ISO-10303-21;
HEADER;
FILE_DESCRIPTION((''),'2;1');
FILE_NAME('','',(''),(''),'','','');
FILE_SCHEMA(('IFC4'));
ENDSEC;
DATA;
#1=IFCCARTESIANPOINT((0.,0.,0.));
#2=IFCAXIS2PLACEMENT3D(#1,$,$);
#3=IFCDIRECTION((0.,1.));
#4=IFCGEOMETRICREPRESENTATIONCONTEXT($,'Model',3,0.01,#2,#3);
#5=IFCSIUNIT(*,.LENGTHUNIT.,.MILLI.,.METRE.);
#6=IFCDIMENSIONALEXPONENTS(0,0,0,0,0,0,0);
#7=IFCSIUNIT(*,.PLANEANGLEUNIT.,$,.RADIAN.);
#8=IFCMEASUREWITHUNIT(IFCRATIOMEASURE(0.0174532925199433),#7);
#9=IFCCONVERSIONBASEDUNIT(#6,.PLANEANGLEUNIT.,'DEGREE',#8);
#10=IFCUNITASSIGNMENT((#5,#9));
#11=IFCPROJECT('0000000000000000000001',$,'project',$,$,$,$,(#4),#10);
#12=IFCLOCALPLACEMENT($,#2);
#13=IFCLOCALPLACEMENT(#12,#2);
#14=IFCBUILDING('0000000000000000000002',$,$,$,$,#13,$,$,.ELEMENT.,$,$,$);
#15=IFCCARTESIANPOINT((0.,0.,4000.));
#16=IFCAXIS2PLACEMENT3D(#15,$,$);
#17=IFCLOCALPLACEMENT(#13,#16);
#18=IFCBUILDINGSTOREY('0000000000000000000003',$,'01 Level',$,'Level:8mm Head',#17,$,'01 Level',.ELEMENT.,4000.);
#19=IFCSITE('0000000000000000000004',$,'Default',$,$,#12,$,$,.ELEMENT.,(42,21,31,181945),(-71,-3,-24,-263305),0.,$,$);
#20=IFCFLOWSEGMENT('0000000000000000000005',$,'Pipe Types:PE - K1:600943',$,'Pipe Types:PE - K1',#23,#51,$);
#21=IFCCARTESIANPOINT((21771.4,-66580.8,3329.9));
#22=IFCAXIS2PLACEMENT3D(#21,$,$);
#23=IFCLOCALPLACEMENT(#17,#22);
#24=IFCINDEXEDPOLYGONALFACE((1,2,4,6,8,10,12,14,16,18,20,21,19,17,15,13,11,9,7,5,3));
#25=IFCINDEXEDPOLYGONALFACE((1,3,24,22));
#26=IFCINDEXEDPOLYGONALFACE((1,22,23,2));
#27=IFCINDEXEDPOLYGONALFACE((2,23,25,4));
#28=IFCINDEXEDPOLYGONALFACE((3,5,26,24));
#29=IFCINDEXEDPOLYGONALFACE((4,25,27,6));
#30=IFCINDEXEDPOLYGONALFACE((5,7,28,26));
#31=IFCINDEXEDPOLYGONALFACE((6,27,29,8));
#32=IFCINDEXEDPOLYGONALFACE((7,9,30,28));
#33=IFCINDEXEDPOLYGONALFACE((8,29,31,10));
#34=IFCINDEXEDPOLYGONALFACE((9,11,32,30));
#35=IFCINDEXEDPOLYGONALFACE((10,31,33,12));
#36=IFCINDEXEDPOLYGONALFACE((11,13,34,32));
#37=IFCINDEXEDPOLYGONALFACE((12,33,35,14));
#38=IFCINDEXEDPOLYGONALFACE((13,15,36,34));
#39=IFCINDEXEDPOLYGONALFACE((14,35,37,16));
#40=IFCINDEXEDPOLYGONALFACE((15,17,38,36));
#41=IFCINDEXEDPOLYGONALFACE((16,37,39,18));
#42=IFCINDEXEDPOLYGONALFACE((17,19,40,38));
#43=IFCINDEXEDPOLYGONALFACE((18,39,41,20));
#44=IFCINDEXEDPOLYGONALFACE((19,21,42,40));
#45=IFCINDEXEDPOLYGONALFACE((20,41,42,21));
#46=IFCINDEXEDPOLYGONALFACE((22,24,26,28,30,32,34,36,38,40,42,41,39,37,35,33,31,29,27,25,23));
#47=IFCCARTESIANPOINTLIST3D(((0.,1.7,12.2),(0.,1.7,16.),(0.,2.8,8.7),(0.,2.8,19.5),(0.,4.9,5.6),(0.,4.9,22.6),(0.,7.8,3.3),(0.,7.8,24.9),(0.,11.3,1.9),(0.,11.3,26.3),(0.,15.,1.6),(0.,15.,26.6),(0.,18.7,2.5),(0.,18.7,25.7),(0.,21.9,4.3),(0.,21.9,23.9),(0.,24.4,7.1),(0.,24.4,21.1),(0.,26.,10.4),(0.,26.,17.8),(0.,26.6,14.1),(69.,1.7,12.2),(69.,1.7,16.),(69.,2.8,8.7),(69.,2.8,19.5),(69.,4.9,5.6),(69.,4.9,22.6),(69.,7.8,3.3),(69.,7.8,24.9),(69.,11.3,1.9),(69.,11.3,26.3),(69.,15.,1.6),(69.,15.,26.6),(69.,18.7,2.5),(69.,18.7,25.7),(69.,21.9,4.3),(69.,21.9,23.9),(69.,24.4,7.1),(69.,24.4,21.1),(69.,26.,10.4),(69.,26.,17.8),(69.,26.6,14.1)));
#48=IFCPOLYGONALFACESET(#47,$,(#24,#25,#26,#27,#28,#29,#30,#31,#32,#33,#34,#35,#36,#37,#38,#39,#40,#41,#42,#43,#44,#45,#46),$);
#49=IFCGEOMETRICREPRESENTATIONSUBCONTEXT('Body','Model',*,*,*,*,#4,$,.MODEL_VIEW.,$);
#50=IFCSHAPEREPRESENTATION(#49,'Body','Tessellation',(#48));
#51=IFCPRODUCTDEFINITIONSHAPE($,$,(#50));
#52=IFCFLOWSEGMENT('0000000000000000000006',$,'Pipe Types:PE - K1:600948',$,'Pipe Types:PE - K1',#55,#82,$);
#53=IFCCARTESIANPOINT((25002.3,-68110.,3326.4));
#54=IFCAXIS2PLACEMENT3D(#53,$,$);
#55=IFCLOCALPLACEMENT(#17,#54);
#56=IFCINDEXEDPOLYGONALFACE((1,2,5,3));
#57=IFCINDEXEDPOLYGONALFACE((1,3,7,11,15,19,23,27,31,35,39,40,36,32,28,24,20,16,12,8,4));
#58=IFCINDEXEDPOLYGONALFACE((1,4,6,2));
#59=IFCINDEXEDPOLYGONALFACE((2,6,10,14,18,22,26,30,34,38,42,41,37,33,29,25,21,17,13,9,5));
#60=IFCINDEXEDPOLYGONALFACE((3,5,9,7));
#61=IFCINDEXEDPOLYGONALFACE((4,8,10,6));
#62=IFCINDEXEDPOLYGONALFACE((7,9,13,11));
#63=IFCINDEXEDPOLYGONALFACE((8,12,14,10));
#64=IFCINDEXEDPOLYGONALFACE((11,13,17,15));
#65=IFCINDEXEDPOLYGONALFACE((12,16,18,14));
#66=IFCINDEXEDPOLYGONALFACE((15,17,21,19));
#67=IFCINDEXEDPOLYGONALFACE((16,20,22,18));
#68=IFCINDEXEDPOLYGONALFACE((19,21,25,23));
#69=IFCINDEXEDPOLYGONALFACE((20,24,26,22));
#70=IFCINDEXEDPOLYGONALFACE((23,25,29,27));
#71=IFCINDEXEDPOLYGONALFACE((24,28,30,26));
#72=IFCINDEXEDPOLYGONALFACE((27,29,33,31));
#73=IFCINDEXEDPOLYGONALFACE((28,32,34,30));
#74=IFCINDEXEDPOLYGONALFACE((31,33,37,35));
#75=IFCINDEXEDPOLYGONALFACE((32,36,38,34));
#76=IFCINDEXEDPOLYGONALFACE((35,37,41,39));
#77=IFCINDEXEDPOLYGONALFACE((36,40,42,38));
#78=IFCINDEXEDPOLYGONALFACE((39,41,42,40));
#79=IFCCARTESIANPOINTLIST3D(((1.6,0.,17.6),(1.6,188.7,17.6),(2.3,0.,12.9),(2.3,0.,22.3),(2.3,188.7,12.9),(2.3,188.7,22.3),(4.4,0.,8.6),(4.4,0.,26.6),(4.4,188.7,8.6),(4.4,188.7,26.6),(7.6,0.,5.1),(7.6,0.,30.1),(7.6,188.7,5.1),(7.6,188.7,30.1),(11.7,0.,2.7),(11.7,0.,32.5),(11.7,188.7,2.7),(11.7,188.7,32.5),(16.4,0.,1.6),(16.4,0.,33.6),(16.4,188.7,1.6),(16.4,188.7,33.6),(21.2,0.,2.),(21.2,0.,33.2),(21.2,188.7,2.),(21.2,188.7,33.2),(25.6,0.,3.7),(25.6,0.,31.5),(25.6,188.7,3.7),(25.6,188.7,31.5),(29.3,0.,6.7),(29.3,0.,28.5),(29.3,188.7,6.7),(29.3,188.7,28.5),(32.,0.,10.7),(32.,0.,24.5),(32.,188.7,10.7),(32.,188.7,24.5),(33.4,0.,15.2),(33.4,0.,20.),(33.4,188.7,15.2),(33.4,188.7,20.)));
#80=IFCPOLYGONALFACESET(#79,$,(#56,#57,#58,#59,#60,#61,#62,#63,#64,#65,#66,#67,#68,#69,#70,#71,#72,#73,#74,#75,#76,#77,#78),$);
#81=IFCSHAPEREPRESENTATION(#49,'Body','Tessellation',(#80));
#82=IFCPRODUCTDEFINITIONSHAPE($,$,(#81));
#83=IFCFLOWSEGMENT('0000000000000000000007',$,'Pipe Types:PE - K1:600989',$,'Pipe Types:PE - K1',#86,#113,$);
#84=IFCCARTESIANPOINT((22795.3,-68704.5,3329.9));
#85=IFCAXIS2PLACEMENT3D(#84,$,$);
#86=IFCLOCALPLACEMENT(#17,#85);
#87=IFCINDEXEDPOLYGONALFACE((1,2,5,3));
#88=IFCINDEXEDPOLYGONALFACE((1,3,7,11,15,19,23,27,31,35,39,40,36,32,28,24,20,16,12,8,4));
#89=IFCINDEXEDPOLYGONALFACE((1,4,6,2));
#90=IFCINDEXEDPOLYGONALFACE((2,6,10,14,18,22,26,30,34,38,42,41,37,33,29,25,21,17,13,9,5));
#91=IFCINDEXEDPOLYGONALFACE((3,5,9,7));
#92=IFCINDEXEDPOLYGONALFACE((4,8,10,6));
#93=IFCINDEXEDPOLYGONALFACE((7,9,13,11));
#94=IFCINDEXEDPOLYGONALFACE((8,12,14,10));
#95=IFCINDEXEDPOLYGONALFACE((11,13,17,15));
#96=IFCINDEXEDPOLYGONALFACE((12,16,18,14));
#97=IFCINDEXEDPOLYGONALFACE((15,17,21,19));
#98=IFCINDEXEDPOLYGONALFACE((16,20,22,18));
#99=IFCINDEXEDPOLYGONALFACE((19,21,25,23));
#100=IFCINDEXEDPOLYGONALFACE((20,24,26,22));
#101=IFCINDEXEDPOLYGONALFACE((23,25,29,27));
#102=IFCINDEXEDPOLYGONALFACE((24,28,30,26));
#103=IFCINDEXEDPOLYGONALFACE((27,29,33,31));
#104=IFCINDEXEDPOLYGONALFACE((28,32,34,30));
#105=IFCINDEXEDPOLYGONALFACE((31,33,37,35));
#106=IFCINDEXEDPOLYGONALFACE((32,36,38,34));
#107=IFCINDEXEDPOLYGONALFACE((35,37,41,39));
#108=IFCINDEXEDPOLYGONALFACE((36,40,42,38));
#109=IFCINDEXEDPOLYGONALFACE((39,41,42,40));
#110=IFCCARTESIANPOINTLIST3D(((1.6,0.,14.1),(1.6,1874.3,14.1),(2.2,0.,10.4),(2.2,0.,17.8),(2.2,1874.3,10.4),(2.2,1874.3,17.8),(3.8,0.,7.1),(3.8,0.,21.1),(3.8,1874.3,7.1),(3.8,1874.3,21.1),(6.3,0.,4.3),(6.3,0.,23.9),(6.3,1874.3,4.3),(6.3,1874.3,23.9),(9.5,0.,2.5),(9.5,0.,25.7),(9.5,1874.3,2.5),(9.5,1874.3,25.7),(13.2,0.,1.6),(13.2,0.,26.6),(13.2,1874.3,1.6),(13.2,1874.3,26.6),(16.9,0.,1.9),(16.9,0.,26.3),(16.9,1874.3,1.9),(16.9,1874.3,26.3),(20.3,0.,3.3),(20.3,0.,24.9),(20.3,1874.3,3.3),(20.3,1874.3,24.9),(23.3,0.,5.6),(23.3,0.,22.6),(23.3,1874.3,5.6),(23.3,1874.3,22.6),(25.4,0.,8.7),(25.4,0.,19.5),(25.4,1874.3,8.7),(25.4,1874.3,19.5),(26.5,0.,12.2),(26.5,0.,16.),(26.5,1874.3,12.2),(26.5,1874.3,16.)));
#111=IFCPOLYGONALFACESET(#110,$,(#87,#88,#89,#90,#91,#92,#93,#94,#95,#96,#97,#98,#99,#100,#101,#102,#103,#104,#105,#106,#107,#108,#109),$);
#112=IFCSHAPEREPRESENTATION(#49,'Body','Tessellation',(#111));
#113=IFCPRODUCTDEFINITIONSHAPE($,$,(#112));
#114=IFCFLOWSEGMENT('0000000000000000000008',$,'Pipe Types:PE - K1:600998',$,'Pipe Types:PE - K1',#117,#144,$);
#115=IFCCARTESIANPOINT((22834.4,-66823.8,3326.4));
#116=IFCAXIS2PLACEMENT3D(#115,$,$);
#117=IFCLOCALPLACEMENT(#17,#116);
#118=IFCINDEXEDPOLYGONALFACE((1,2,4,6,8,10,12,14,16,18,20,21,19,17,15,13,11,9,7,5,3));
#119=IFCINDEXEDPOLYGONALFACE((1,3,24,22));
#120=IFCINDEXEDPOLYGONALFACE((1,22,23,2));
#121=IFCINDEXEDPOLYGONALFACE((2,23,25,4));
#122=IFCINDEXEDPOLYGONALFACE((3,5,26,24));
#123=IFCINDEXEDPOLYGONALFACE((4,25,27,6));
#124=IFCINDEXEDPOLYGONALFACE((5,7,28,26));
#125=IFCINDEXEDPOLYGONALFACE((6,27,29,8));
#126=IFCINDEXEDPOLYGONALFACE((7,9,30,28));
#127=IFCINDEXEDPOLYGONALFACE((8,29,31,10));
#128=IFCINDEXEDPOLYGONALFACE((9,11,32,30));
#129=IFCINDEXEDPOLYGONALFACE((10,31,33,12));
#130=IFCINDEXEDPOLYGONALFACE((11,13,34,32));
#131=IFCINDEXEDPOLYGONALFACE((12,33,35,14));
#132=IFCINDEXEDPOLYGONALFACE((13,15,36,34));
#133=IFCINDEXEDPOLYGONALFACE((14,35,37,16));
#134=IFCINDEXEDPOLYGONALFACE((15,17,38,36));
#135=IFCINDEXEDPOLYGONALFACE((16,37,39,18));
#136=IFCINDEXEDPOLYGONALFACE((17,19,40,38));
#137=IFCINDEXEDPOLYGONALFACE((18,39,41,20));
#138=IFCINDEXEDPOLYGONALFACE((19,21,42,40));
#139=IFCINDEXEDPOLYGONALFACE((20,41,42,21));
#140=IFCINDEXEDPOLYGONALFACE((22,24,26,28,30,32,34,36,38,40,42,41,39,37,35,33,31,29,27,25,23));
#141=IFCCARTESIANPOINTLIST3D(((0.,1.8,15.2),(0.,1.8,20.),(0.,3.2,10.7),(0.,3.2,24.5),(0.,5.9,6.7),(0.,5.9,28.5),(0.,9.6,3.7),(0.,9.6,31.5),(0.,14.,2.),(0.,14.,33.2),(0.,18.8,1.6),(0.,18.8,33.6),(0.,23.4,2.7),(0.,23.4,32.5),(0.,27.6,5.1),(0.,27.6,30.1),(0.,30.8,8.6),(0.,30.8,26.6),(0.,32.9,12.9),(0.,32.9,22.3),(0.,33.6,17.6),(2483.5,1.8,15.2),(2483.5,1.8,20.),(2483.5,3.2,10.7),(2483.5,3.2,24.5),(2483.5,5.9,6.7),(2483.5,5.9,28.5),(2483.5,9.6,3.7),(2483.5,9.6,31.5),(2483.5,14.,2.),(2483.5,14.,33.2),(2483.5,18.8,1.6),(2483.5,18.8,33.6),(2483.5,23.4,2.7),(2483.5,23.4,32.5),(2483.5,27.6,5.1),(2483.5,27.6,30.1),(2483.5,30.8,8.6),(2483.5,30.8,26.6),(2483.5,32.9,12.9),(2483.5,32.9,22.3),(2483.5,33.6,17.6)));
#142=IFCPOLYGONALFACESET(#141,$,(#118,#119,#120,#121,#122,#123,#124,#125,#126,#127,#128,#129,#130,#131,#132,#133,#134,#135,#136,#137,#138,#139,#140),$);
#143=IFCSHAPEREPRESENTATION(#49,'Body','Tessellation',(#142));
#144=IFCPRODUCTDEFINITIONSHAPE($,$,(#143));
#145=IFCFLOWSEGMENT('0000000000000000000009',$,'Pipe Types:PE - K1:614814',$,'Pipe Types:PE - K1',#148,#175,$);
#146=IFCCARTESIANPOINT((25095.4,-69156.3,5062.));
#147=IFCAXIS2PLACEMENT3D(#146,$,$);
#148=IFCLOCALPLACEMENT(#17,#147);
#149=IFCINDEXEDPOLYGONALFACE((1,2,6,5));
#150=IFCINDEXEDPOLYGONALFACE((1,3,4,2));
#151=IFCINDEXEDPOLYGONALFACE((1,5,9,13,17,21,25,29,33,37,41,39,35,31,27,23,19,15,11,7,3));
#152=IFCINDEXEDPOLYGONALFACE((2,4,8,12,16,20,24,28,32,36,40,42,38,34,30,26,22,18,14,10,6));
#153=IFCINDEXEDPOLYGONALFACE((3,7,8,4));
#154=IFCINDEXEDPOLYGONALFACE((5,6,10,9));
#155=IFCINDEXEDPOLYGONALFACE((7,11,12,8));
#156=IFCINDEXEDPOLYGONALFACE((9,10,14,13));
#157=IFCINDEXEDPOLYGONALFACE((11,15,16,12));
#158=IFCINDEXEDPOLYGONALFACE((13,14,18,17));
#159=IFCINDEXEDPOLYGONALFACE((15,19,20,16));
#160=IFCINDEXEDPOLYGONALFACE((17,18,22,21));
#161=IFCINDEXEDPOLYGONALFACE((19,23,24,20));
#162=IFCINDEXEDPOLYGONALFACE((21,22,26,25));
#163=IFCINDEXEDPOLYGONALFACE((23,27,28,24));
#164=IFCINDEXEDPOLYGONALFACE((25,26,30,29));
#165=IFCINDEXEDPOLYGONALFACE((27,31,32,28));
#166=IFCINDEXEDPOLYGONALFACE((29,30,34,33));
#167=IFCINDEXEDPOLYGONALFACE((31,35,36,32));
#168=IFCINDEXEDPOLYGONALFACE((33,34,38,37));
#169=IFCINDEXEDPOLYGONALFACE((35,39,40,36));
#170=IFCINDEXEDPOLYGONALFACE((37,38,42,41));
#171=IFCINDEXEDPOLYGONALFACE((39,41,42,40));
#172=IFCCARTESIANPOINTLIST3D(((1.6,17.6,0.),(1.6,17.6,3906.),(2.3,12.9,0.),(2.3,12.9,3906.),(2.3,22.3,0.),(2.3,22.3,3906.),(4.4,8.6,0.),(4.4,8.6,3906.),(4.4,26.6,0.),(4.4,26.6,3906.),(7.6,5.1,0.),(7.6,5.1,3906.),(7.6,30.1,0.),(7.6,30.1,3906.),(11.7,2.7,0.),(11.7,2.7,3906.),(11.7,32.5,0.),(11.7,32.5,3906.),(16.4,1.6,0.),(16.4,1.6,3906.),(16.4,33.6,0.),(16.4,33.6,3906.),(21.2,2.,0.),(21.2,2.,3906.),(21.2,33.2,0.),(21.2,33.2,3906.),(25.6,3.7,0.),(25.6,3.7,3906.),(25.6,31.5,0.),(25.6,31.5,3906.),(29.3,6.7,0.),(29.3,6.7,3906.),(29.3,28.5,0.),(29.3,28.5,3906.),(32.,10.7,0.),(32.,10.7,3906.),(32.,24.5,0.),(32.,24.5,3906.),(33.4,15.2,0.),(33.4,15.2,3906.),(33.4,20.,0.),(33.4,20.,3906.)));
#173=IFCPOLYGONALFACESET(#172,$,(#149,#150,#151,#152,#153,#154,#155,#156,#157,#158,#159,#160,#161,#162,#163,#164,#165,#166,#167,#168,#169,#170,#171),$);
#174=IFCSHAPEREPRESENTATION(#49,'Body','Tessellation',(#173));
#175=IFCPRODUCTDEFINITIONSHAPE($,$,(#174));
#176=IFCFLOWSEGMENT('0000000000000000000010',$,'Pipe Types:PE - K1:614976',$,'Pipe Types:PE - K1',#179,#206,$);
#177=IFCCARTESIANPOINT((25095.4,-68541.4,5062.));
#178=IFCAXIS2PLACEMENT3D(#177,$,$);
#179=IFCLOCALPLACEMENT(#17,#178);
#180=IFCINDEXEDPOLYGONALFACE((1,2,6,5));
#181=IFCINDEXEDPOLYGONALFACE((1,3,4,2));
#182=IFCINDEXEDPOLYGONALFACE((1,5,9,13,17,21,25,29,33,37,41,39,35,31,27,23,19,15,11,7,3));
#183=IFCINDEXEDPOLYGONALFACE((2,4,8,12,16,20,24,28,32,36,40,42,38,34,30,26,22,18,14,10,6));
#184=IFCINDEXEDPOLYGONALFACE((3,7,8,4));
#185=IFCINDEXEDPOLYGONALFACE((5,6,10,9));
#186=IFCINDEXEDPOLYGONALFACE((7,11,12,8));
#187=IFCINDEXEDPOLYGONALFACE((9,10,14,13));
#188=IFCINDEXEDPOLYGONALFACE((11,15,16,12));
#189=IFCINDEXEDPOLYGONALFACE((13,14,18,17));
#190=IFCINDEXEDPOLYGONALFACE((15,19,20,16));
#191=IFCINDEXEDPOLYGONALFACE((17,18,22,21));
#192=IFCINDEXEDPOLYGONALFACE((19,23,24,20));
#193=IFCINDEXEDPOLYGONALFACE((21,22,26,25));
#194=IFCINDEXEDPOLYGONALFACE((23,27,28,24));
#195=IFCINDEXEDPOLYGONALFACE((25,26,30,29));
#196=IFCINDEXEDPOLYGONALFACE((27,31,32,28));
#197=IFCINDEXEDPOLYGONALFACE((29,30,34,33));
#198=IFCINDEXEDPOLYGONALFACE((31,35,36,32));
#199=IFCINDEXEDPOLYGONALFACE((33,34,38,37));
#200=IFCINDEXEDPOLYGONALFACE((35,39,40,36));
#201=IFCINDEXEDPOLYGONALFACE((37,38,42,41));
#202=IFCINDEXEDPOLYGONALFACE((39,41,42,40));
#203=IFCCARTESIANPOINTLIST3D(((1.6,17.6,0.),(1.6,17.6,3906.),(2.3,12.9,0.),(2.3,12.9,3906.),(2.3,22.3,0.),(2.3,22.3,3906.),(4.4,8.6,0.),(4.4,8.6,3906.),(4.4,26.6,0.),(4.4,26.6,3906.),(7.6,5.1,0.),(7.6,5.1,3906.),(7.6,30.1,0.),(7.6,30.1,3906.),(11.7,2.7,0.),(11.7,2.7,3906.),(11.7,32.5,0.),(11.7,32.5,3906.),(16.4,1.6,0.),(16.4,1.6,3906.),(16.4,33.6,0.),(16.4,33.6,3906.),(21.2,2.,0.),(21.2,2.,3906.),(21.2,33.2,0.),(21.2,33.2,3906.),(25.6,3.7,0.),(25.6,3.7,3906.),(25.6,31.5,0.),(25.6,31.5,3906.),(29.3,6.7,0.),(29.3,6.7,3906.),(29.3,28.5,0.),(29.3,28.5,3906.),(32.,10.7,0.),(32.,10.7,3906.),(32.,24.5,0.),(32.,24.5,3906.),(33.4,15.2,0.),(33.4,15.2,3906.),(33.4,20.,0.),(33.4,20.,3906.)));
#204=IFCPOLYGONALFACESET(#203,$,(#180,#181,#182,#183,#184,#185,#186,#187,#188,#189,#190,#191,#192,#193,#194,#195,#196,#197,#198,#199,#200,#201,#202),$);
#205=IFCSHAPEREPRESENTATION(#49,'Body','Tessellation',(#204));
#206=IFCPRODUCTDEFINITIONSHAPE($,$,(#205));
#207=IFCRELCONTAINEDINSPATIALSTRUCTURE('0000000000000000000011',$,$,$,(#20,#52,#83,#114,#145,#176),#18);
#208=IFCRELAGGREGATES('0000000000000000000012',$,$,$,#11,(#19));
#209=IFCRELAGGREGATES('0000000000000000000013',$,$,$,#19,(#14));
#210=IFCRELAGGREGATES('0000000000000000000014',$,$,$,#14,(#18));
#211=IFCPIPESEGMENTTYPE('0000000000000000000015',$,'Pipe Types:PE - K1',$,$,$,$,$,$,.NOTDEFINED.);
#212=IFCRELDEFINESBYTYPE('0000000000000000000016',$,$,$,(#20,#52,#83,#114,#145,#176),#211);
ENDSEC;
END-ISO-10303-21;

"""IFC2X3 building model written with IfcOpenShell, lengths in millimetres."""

from ifc_helpers import new_model, entity, si_unit, converted_unit, direction, frame, frame_2d, origin, origin_2d_with_axis, place, context, subcontext, project, spatial, circle, extrude, type_object, element, save


model = new_model("IFC2X3")

# Units and contexts
model_context = context("Model", 3, precision=0.01, world=origin(), true_north=direction((0.0, 1.0)))
body_context = subcontext(model_context, "Body", "Model", "MODEL_VIEW")
ifc_project = project(units=[si_unit("LENGTHUNIT", "METRE", prefix="MILLI"), converted_unit("PLANEANGLEUNIT", "DEGREE", entity("IfcRatioMeasure", 0.0174532925199433), si_unit("PLANEANGLEUNIT", "RADIAN"), dimensions=[0, 0, 0, 0, 0, 0, 0])], contexts=[model_context])

# Site, building, storey
site_placement = place(None, origin())
site = spatial("IfcSite", under=ifc_project, at=site_placement, Name="Default", CompositionType="ELEMENT", RefLatitude=(42, 21, 31, 181945), RefLongitude=(-71, -3, -24, -263305), RefElevation=0.0)
building_placement = place(site_placement, origin())
building = spatial("IfcBuilding", under=site, at=building_placement, CompositionType="ELEMENT")
storey_placement = place(building_placement, frame((0.0, 0.0, 4000.0)))
storey = spatial("IfcBuildingStorey", under=building, at=storey_placement, Name="01 Level", ObjectType="Level:8mm Head", LongName="01 Level", CompositionType="ELEMENT", Elevation=4000.0)

# Flow segments
pipe_segment_type = type_object("IfcPipeSegmentType", Name="Pipe Types:PE - K1", PredefinedType="NOTDEFINED")
flow_segment_1_placement = place(storey_placement, frame((21771.4, -66580.8, 3329.9)))
element("IfcFlowSegment", 1, at=flow_segment_1_placement, inside=storey, type_object=pipe_segment_type, Name="Pipe Types:PE - K1:600943", ObjectType="Pipe Types:PE - K1", context=body_context, shape_type="SweptSolid", body=[
    extrude(circle(Radius=12.5, at=frame_2d((0.0, 0.0), x_axis=(1.0, 0.0))), frame((0.0, 14.1, 14.1), z_axis=(1.0, 0.0, 0.0), x_axis=(0.0, 1.0, 0.0)), (0.0, 0.0, 1.0), 69.0),
])
flow_segment_2_placement = place(storey_placement, frame((25002.3, -68110.0, 3326.4)))
element("IfcFlowSegment", 2, at=flow_segment_2_placement, inside=storey, type_object=pipe_segment_type, Name="Pipe Types:PE - K1:600948", ObjectType="Pipe Types:PE - K1", context=body_context, shape_type="SweptSolid", body=[
    extrude(circle(Radius=16.0, at=frame_2d((0.0, 0.0), x_axis=(1.0, 0.0))), frame((17.6, 0.0, 17.6), z_axis=(0.0, 1.0, 0.0), x_axis=(-1.0, 0.0, 0.0)), (0.0, 0.0, 1.0), 188.7),
])
flow_segment_3_placement = place(storey_placement, frame((22795.3, -68704.5, 3329.9)))
element("IfcFlowSegment", 3, at=flow_segment_3_placement, inside=storey, type_object=pipe_segment_type, Name="Pipe Types:PE - K1:600989", ObjectType="Pipe Types:PE - K1", context=body_context, shape_type="SweptSolid", body=[
    extrude(circle(Radius=12.5, at=frame_2d((0.0, 0.0), x_axis=(1.0, 0.0))), frame((14.1, 0.0, 14.1), z_axis=(0.0, 1.0, 0.0), x_axis=(-1.0, 0.0, 0.0)), (0.0, 0.0, 1.0), 1874.3),
])
flow_segment_4_placement = place(storey_placement, frame((22834.4, -66823.8, 3326.4)))
element("IfcFlowSegment", 4, at=flow_segment_4_placement, inside=storey, type_object=pipe_segment_type, Name="Pipe Types:PE - K1:600998", ObjectType="Pipe Types:PE - K1", context=body_context, shape_type="SweptSolid", body=[
    extrude(circle(Radius=16.0, at=frame_2d((0.0, 0.0), x_axis=(1.0, 0.0))), frame((0.0, 17.6, 17.6), z_axis=(1.0, 0.0, 0.0), x_axis=(0.0, 1.0, 0.0)), (0.0, 0.0, 1.0), 2483.5),
])
for number, where, name in (
    (5, (25095.4, -69156.3, 5062.0), "Pipe Types:PE - K1:614814"),
    (6, (25095.4, -68541.4, 5062.0), "Pipe Types:PE - K1:614976"),
):
    element("IfcFlowSegment", number, at=place(storey_placement, frame(where)), inside=storey, type_object=pipe_segment_type, Name=name, ObjectType="Pipe Types:PE - K1", context=body_context, shape_type="SweptSolid", body=[
        extrude(circle(Radius=16.0, at=origin_2d_with_axis()), frame((17.6, 17.6, 0.0), z_axis=(0.0, 0.0, 1.0), x_axis=(-1.0, 0.0, 0.0)), (0.0, 0.0, 1.0), 3906.0),
    ])

save(model, "model.ifc")
